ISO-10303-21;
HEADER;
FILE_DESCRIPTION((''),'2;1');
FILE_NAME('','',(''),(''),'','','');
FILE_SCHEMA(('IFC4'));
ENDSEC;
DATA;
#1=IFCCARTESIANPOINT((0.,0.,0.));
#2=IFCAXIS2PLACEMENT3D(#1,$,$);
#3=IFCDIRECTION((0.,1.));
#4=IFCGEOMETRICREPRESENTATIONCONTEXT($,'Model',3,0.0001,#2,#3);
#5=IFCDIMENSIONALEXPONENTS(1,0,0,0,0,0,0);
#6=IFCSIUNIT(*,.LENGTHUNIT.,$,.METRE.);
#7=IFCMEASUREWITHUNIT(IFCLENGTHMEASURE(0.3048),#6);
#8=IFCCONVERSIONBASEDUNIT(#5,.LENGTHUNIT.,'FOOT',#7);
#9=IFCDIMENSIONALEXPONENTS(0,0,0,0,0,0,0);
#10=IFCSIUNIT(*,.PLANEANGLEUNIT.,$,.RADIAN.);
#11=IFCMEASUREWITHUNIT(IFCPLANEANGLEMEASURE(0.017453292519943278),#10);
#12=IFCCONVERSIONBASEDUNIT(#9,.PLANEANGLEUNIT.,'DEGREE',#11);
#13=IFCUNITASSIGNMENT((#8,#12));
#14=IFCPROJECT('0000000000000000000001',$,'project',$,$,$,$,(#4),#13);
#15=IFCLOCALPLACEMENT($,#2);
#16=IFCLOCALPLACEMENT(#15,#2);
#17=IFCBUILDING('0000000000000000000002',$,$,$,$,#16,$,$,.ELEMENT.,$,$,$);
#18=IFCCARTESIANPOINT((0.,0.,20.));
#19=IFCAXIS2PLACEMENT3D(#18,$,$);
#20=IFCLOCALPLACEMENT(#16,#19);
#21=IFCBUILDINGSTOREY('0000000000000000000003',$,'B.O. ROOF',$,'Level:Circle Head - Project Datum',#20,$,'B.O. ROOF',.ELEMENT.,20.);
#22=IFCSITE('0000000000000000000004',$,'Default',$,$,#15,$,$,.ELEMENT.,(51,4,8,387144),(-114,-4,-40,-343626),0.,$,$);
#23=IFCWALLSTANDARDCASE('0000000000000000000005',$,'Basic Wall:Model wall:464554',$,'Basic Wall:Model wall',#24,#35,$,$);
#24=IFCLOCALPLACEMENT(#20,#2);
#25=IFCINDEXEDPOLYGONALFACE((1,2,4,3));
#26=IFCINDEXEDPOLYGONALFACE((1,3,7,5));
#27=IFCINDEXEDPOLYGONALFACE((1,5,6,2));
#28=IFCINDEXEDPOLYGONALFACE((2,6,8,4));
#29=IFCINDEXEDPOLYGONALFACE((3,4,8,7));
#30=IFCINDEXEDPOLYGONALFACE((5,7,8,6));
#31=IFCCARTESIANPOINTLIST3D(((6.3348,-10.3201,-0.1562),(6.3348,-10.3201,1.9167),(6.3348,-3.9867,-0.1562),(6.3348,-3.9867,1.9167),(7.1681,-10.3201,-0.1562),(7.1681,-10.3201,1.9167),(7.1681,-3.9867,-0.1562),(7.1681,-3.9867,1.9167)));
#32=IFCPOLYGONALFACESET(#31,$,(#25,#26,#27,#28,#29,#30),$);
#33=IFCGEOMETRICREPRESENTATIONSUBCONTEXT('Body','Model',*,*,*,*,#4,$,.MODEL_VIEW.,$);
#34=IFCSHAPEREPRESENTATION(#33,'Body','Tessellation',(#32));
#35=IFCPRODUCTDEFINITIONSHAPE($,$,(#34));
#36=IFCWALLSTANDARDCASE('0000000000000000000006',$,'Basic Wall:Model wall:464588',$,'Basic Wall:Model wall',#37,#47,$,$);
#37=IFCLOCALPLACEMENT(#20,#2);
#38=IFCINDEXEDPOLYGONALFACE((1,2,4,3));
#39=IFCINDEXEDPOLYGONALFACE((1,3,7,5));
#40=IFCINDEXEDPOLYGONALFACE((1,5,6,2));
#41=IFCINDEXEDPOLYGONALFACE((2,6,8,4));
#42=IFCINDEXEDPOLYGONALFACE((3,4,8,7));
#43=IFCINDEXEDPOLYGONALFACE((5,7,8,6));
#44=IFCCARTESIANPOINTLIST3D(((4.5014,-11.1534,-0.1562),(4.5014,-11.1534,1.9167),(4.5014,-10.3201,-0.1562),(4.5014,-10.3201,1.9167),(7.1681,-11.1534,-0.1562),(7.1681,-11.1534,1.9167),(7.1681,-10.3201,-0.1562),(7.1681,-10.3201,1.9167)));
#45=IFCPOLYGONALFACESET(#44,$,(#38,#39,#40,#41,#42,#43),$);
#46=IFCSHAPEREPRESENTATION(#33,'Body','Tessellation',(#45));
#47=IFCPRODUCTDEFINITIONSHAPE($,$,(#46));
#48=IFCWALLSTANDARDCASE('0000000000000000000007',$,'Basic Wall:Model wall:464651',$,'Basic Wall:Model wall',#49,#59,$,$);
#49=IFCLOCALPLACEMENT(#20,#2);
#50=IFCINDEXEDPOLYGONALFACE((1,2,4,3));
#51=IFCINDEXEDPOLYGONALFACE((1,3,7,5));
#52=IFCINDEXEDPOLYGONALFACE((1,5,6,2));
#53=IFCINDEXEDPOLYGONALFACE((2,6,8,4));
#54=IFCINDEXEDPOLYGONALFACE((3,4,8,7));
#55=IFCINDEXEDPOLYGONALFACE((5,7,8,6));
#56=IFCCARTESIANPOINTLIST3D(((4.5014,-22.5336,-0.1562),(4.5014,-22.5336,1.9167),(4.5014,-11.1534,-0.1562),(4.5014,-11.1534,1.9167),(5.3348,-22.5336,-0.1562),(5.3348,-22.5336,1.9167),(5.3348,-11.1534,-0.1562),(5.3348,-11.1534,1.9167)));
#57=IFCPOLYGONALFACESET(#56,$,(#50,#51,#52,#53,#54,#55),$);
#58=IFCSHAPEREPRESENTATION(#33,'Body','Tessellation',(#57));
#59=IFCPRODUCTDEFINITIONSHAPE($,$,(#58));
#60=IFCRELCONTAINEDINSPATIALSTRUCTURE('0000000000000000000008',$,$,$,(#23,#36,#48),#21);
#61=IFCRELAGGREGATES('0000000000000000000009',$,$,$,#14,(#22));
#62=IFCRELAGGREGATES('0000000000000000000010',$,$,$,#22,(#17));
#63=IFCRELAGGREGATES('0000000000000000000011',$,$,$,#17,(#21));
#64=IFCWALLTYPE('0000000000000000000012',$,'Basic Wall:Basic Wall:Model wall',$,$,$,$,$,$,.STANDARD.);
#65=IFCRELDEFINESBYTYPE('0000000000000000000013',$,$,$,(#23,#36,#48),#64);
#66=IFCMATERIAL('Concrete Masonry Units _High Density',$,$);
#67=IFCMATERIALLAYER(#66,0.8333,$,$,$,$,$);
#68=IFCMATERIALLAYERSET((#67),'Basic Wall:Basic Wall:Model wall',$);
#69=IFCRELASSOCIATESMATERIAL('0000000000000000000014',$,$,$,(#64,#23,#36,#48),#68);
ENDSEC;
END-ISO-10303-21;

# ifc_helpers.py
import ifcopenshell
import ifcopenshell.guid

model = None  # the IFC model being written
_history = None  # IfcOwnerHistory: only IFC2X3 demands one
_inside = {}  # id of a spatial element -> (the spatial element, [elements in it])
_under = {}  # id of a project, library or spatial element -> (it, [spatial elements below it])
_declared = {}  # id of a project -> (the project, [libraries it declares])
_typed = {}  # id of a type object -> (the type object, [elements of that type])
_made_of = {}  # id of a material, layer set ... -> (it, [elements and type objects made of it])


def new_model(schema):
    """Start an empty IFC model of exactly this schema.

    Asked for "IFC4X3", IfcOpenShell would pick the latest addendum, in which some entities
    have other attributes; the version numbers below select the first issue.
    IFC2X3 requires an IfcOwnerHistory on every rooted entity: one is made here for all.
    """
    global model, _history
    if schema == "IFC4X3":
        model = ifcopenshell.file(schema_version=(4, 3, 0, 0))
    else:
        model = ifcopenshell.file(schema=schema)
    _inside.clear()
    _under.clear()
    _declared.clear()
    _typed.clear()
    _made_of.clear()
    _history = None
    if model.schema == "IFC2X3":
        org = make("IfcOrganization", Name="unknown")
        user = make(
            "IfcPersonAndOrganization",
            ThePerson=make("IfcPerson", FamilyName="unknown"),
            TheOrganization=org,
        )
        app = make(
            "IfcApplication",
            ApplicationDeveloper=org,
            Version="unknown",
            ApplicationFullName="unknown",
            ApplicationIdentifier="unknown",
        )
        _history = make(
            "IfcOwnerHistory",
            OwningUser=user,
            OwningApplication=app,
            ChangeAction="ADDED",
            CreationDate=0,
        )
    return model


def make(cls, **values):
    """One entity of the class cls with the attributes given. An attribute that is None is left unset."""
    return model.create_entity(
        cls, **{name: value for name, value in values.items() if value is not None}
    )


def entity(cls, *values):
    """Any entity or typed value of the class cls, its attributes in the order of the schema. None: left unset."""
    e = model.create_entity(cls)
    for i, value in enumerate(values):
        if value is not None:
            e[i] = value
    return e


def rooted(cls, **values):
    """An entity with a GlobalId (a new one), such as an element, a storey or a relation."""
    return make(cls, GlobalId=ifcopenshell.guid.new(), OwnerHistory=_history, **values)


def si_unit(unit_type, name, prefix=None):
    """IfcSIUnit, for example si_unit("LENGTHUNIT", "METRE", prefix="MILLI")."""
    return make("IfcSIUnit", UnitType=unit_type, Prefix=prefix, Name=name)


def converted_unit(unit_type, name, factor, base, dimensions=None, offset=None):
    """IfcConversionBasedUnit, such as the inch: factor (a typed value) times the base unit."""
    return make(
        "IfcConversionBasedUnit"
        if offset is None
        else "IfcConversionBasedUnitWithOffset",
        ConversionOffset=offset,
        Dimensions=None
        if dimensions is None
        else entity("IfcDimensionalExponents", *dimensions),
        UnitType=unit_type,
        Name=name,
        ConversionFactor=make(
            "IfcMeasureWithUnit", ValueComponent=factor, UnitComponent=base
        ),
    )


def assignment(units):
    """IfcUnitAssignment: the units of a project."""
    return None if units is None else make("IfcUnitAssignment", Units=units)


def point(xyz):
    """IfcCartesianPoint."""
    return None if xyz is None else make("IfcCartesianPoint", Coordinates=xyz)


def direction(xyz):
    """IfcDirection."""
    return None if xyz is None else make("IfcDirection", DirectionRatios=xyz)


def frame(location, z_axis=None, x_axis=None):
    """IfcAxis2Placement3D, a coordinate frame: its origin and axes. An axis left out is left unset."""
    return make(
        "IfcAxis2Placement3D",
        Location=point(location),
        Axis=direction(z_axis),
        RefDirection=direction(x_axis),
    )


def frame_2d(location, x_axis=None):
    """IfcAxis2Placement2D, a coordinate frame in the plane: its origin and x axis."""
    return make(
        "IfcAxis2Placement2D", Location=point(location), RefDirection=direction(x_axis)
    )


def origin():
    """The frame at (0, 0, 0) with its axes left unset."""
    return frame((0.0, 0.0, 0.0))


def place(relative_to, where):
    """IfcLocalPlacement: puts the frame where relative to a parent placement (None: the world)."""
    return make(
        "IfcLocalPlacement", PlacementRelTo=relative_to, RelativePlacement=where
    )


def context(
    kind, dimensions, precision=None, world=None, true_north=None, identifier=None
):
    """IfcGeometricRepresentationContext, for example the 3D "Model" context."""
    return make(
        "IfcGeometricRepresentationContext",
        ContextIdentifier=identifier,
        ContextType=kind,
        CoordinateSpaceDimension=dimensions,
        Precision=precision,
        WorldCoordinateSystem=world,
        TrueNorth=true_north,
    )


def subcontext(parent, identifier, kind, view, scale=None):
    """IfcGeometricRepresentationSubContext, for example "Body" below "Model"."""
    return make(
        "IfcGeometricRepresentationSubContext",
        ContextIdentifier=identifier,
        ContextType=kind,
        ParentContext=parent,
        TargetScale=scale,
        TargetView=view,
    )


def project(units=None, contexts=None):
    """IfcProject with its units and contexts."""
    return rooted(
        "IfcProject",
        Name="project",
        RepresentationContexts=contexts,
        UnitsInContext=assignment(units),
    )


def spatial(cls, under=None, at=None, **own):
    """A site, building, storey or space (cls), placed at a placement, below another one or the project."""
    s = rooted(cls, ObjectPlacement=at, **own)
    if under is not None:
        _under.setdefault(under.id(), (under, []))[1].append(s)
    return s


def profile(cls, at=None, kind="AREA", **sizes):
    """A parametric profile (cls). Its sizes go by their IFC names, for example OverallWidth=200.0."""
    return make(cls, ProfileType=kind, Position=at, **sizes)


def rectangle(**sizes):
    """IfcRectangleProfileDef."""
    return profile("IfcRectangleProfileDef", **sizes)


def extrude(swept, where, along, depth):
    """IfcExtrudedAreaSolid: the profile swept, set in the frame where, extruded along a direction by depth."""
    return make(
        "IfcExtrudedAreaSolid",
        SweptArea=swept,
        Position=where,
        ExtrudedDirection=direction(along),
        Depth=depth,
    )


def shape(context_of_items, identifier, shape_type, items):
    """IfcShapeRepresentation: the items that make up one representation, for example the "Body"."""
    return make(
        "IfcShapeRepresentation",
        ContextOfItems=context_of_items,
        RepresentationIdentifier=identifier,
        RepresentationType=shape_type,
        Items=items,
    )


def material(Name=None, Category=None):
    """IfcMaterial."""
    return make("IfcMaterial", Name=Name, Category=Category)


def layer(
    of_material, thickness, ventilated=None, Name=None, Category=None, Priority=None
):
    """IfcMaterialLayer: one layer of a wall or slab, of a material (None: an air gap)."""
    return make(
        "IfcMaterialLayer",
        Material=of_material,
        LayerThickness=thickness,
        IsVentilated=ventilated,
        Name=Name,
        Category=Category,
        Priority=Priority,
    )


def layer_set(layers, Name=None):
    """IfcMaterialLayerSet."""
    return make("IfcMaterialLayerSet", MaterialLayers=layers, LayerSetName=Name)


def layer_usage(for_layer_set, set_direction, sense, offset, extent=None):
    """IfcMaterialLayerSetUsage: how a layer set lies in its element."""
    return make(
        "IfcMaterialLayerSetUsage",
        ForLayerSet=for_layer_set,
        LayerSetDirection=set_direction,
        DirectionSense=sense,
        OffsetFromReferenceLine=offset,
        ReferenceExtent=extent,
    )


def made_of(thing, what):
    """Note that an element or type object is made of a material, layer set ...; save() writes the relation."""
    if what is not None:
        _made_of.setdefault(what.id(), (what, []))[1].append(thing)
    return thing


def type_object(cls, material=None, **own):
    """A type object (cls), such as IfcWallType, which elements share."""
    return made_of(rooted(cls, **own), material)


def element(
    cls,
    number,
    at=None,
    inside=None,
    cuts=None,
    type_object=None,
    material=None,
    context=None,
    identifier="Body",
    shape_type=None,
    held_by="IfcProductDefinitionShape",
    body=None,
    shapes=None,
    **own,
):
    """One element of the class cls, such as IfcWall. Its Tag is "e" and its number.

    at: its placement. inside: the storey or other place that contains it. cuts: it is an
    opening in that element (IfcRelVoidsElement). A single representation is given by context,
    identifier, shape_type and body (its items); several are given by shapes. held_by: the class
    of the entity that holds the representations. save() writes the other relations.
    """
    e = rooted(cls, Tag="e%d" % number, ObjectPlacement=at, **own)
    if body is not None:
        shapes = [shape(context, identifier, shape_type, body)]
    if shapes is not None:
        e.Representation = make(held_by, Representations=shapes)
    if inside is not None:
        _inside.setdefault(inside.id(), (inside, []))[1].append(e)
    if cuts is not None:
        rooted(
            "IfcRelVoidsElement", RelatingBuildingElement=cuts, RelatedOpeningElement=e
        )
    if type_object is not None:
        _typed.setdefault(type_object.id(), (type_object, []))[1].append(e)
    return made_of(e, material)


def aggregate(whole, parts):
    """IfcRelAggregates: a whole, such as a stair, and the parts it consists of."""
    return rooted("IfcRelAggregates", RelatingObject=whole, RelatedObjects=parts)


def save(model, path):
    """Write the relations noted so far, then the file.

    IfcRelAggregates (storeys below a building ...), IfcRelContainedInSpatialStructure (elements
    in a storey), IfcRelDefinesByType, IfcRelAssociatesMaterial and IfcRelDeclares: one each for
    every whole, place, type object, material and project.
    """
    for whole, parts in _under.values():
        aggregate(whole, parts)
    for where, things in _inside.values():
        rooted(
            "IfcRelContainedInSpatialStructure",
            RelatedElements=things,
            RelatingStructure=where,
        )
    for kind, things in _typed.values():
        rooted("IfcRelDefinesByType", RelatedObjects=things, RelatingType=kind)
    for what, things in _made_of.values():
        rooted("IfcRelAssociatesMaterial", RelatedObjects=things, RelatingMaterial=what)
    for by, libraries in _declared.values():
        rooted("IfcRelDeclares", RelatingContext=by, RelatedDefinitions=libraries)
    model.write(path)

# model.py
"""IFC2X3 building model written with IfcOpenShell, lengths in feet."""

from ifc_helpers import new_model, entity, si_unit, converted_unit, direction, frame, frame_2d, origin, place, context, subcontext, project, spatial, rectangle, extrude, material, layer, layer_set, layer_usage, type_object, element, save


model = new_model("IFC2X3")

# Units and contexts
model_context = context("Model", 3, precision=0.0001, world=origin(), true_north=direction((0.0, 1.0)))
body_context = subcontext(model_context, "Body", "Model", "MODEL_VIEW")
ifc_project = project(units=[converted_unit("LENGTHUNIT", "FOOT", entity("IfcLengthMeasure", 0.3048), si_unit("LENGTHUNIT", "METRE"), dimensions=[1, 0, 0, 0, 0, 0, 0]), converted_unit("PLANEANGLEUNIT", "DEGREE", entity("IfcPlaneAngleMeasure", 0.017453292519943278), si_unit("PLANEANGLEUNIT", "RADIAN"), dimensions=[0, 0, 0, 0, 0, 0, 0])], contexts=[model_context])

# Site, building, storey
site_placement = place(None, origin())
site = spatial("IfcSite", under=ifc_project, at=site_placement, Name="Default", CompositionType="ELEMENT", RefLatitude=(51, 4, 8, 387144), RefLongitude=(-114, -4, -40, -343626), RefElevation=0.0)
building_placement = place(site_placement, origin())
building = spatial("IfcBuilding", under=site, at=building_placement, CompositionType="ELEMENT")
storey_placement = place(building_placement, frame((0.0, 0.0, 20.0)))
storey = spatial("IfcBuildingStorey", under=building, at=storey_placement, Name="B.O. ROOF", ObjectType="Level:Circle Head - Project Datum", LongName="B.O. ROOF", CompositionType="ELEMENT", Elevation=20.0)

# Walls
ifc_material_1 = material(Name="Concrete Masonry Units _High Density")
ifc_layer = layer(ifc_material_1, 0.8333)
ifc_layer_set = layer_set([ifc_layer], Name="Basic Wall:Basic Wall:Model wall")
wall_type = type_object("IfcWallType", Name="Basic Wall:Basic Wall:Model wall", PredefinedType="STANDARD", material=ifc_layer_set)
ifc_layer_usage_1 = layer_usage(ifc_layer_set, "AXIS2", "NEGATIVE", 0.4167)
wall_1_placement = place(storey_placement, frame((6.7514, -3.9867, -0.1562), z_axis=(0.0, 0.0, 1.0), x_axis=(0.0, -1.0, 0.0)))
element("IfcWallStandardCase", 1, at=wall_1_placement, inside=storey, type_object=wall_type, material=ifc_layer_usage_1, Name="Basic Wall:Model wall:464554", ObjectType="Basic Wall:Model wall", context=body_context, shape_type="SweptSolid", body=[
    extrude(rectangle(XDim=6.3333, YDim=0.8333, at=frame_2d((3.1667, 0.0), x_axis=(-1.0, 0.0))), origin(), (0.0, 0.0, 1.0), 2.0728),
])
ifc_layer_usage_2 = layer_usage(ifc_layer_set, "AXIS2", "NEGATIVE", 0.4167)
wall_2_placement = place(storey_placement, frame((7.1681, -10.7367, -0.1562), z_axis=(0.0, 0.0, 1.0), x_axis=(-1.0, 0.0, 0.0)))
element("IfcWallStandardCase", 2, at=wall_2_placement, inside=storey, type_object=wall_type, material=ifc_layer_usage_2, Name="Basic Wall:Model wall:464588", ObjectType="Basic Wall:Model wall", context=body_context, shape_type="SweptSolid", body=[
    extrude(rectangle(XDim=2.6667, YDim=0.8333, at=frame_2d((1.3333, 0.0), x_axis=(-1.0, 0.0))), origin(), (0.0, 0.0, 1.0), 2.0728),
])
ifc_layer_usage_3 = layer_usage(ifc_layer_set, "AXIS2", "NEGATIVE", 0.4167)
wall_3_placement = place(storey_placement, frame((4.9181, -11.1534, -0.1562), z_axis=(0.0, 0.0, 1.0), x_axis=(0.0, -1.0, 0.0)))
element("IfcWallStandardCase", 3, at=wall_3_placement, inside=storey, type_object=wall_type, material=ifc_layer_usage_3, Name="Basic Wall:Model wall:464651", ObjectType="Basic Wall:Model wall", context=body_context, shape_type="SweptSolid", body=[
    extrude(rectangle(XDim=11.3802, YDim=0.8333, at=frame_2d((5.6901, 0.0), x_axis=(-1.0, 0.0))), origin(), (0.0, 0.0, 1.0), 2.0728),
])

save(model, "model.ifc")
